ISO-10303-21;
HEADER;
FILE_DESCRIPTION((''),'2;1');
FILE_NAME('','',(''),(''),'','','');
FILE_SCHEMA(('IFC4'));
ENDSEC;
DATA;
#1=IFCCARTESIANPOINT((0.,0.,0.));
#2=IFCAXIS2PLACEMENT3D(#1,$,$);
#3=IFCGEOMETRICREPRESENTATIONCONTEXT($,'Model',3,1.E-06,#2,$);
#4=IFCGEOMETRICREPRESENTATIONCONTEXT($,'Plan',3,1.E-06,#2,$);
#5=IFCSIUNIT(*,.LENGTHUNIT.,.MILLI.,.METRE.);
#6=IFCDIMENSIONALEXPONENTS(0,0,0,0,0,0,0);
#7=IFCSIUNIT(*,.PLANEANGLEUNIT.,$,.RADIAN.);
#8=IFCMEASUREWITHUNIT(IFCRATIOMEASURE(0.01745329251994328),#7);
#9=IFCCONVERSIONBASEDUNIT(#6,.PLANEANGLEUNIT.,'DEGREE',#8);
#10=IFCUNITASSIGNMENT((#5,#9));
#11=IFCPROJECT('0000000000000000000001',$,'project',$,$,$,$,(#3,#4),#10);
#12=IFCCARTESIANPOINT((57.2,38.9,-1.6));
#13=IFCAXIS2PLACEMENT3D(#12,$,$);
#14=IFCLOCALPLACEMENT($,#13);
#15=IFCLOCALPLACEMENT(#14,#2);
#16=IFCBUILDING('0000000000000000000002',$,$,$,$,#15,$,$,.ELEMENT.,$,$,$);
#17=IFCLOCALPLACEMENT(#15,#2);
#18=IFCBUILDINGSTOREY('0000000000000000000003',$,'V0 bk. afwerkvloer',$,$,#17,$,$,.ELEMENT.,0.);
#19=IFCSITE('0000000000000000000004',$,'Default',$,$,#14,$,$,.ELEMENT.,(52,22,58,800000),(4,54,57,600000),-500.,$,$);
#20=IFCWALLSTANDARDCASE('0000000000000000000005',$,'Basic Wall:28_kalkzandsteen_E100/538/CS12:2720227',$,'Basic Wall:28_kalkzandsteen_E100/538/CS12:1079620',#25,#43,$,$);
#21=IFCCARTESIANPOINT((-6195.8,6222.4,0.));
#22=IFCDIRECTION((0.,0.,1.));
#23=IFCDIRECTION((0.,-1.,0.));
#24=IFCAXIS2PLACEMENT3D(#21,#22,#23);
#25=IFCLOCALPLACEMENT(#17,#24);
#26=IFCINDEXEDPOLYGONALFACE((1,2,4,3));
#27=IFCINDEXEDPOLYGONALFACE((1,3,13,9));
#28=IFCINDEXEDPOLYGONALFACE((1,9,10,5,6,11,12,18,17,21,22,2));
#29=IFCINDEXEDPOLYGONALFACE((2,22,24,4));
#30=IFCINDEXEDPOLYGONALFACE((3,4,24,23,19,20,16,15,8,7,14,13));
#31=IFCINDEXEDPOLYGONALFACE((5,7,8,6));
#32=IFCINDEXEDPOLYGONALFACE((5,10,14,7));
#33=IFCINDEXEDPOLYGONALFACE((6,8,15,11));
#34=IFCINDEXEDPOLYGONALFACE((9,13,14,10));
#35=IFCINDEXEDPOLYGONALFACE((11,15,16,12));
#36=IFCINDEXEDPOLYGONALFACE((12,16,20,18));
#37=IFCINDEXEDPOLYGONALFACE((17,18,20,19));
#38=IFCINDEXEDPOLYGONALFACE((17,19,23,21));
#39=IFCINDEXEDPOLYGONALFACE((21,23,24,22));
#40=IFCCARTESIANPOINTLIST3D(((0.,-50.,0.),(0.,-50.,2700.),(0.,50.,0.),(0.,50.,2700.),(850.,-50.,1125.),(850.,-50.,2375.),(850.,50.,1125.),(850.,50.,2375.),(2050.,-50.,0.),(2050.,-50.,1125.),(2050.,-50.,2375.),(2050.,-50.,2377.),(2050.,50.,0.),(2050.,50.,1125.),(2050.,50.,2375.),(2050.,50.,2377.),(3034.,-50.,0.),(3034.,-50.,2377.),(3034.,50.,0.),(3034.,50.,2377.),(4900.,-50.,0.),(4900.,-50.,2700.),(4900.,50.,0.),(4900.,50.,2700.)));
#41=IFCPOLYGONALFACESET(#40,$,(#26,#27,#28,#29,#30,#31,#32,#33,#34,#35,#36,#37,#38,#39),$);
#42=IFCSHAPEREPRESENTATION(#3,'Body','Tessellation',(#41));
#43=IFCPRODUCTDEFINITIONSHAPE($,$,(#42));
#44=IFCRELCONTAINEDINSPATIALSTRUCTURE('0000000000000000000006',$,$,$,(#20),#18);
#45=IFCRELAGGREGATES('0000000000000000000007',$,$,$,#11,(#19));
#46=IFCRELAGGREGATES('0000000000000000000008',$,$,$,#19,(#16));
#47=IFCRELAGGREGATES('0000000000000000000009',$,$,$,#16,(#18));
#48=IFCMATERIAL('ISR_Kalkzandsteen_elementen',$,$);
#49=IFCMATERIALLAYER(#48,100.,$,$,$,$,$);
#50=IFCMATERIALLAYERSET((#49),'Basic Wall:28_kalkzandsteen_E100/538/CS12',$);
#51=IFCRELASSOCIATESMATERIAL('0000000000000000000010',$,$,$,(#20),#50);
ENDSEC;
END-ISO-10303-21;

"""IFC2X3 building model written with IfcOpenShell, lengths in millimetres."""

from ifc_helpers import new_model, entity, si_unit, converted_unit, frame, frame_2d, origin, origin_2d_with_axis, place, context, project, spatial, rectangle, extrude, material, layer, layer_set, layer_usage, element, save


model = new_model("IFC2X3")

# Units and contexts
model_context = context("Model", 3, precision=1e-06, world=origin())
plan_context = context("Plan", 3, precision=1e-06, world=origin())
ifc_project = project(units=[si_unit("LENGTHUNIT", "METRE", prefix="MILLI"), converted_unit("PLANEANGLEUNIT", "DEGREE", entity("IfcRatioMeasure", 0.01745329251994328), si_unit("PLANEANGLEUNIT", "RADIAN"), dimensions=[0, 0, 0, 0, 0, 0, 0])], contexts=[model_context, plan_context])

# Site, building, storey
site_placement = place(None, frame((57.2, 38.9, -1.6)))
site = spatial("IfcSite", under=ifc_project, at=site_placement, Name="Default", CompositionType="ELEMENT", RefLatitude=(52, 22, 58, 800000), RefLongitude=(4, 54, 57, 600000), RefElevation=-500.0)
building_placement = place(site_placement, origin())
building = spatial("IfcBuilding", under=site, at=building_placement, CompositionType="ELEMENT")
storey_placement = place(building_placement, origin())
storey = spatial("IfcBuildingStorey", under=building, at=storey_placement, Name="V0 bk. afwerkvloer", CompositionType="ELEMENT", Elevation=0.0)

# Shared definitions
ifc_material_1 = material(Name="ISR_Kalkzandsteen_elementen")
ifc_layer_1 = layer(ifc_material_1, 100.0)
ifc_layer_set_1 = layer_set([ifc_layer_1], Name="Basic Wall:28_kalkzandsteen_E100/538/CS12")

# Wall, openings
ifc_layer_usage_1 = layer_usage(ifc_layer_set_1, "AXIS2", "NEGATIVE", 50.0)
wall_1_placement = place(storey_placement, frame((-6195.8, 6222.4, 0.0), z_axis=(0.0, 0.0, 1.0), x_axis=(0.0, -1.0, 0.0)))
wall_1 = element("IfcWallStandardCase", 1, at=wall_1_placement, inside=storey, material=ifc_layer_usage_1, Name="Basic Wall:28_kalkzandsteen_E100/538/CS12:2720227", ObjectType="Basic Wall:28_kalkzandsteen_E100/538/CS12:1079620", context=model_context, shape_type="SweptSolid", body=[
    extrude(rectangle(XDim=4900.0, YDim=100.0, at=frame_2d((2450.0, 0.0), x_axis=(-1.0, 0.0))), origin(), (0.0, 0.0, 1.0), 2700.0),
])
opening_1_placement = place(wall_1_placement, origin())
element("IfcOpeningElement", 2, at=opening_1_placement, cuts=wall_1, ObjectType="Opening", context=model_context, shape_type="SweptSolid", body=[
    extrude(rectangle(XDim=1250.0, YDim=1200.0, at=origin_2d_with_axis()), frame((1450.0, -202.4, 1750.0), z_axis=(0.0, 1.0, 0.0), x_axis=(0.0, 0.0, 1.0)), (0.0, 0.0, 1.0), 404.8),
])
opening_2_placement = place(wall_1_placement, origin())
element("IfcOpeningElement", 3, at=opening_2_placement, cuts=wall_1, ObjectType="Opening", context=model_context, shape_type="SweptSolid", body=[
    extrude(rectangle(XDim=2377.0, YDim=984.0, at=frame_2d((0.0, 0.0), x_axis=(0.0, 1.0))), frame((2542.0, -1574.0, 1188.5), z_axis=(0.0, 1.0, 0.0), x_axis=(-1.0, 0.0, 0.0)), (0.0, 0.0, 1.0), 3048.0),
])

save(model, "model.ifc")
